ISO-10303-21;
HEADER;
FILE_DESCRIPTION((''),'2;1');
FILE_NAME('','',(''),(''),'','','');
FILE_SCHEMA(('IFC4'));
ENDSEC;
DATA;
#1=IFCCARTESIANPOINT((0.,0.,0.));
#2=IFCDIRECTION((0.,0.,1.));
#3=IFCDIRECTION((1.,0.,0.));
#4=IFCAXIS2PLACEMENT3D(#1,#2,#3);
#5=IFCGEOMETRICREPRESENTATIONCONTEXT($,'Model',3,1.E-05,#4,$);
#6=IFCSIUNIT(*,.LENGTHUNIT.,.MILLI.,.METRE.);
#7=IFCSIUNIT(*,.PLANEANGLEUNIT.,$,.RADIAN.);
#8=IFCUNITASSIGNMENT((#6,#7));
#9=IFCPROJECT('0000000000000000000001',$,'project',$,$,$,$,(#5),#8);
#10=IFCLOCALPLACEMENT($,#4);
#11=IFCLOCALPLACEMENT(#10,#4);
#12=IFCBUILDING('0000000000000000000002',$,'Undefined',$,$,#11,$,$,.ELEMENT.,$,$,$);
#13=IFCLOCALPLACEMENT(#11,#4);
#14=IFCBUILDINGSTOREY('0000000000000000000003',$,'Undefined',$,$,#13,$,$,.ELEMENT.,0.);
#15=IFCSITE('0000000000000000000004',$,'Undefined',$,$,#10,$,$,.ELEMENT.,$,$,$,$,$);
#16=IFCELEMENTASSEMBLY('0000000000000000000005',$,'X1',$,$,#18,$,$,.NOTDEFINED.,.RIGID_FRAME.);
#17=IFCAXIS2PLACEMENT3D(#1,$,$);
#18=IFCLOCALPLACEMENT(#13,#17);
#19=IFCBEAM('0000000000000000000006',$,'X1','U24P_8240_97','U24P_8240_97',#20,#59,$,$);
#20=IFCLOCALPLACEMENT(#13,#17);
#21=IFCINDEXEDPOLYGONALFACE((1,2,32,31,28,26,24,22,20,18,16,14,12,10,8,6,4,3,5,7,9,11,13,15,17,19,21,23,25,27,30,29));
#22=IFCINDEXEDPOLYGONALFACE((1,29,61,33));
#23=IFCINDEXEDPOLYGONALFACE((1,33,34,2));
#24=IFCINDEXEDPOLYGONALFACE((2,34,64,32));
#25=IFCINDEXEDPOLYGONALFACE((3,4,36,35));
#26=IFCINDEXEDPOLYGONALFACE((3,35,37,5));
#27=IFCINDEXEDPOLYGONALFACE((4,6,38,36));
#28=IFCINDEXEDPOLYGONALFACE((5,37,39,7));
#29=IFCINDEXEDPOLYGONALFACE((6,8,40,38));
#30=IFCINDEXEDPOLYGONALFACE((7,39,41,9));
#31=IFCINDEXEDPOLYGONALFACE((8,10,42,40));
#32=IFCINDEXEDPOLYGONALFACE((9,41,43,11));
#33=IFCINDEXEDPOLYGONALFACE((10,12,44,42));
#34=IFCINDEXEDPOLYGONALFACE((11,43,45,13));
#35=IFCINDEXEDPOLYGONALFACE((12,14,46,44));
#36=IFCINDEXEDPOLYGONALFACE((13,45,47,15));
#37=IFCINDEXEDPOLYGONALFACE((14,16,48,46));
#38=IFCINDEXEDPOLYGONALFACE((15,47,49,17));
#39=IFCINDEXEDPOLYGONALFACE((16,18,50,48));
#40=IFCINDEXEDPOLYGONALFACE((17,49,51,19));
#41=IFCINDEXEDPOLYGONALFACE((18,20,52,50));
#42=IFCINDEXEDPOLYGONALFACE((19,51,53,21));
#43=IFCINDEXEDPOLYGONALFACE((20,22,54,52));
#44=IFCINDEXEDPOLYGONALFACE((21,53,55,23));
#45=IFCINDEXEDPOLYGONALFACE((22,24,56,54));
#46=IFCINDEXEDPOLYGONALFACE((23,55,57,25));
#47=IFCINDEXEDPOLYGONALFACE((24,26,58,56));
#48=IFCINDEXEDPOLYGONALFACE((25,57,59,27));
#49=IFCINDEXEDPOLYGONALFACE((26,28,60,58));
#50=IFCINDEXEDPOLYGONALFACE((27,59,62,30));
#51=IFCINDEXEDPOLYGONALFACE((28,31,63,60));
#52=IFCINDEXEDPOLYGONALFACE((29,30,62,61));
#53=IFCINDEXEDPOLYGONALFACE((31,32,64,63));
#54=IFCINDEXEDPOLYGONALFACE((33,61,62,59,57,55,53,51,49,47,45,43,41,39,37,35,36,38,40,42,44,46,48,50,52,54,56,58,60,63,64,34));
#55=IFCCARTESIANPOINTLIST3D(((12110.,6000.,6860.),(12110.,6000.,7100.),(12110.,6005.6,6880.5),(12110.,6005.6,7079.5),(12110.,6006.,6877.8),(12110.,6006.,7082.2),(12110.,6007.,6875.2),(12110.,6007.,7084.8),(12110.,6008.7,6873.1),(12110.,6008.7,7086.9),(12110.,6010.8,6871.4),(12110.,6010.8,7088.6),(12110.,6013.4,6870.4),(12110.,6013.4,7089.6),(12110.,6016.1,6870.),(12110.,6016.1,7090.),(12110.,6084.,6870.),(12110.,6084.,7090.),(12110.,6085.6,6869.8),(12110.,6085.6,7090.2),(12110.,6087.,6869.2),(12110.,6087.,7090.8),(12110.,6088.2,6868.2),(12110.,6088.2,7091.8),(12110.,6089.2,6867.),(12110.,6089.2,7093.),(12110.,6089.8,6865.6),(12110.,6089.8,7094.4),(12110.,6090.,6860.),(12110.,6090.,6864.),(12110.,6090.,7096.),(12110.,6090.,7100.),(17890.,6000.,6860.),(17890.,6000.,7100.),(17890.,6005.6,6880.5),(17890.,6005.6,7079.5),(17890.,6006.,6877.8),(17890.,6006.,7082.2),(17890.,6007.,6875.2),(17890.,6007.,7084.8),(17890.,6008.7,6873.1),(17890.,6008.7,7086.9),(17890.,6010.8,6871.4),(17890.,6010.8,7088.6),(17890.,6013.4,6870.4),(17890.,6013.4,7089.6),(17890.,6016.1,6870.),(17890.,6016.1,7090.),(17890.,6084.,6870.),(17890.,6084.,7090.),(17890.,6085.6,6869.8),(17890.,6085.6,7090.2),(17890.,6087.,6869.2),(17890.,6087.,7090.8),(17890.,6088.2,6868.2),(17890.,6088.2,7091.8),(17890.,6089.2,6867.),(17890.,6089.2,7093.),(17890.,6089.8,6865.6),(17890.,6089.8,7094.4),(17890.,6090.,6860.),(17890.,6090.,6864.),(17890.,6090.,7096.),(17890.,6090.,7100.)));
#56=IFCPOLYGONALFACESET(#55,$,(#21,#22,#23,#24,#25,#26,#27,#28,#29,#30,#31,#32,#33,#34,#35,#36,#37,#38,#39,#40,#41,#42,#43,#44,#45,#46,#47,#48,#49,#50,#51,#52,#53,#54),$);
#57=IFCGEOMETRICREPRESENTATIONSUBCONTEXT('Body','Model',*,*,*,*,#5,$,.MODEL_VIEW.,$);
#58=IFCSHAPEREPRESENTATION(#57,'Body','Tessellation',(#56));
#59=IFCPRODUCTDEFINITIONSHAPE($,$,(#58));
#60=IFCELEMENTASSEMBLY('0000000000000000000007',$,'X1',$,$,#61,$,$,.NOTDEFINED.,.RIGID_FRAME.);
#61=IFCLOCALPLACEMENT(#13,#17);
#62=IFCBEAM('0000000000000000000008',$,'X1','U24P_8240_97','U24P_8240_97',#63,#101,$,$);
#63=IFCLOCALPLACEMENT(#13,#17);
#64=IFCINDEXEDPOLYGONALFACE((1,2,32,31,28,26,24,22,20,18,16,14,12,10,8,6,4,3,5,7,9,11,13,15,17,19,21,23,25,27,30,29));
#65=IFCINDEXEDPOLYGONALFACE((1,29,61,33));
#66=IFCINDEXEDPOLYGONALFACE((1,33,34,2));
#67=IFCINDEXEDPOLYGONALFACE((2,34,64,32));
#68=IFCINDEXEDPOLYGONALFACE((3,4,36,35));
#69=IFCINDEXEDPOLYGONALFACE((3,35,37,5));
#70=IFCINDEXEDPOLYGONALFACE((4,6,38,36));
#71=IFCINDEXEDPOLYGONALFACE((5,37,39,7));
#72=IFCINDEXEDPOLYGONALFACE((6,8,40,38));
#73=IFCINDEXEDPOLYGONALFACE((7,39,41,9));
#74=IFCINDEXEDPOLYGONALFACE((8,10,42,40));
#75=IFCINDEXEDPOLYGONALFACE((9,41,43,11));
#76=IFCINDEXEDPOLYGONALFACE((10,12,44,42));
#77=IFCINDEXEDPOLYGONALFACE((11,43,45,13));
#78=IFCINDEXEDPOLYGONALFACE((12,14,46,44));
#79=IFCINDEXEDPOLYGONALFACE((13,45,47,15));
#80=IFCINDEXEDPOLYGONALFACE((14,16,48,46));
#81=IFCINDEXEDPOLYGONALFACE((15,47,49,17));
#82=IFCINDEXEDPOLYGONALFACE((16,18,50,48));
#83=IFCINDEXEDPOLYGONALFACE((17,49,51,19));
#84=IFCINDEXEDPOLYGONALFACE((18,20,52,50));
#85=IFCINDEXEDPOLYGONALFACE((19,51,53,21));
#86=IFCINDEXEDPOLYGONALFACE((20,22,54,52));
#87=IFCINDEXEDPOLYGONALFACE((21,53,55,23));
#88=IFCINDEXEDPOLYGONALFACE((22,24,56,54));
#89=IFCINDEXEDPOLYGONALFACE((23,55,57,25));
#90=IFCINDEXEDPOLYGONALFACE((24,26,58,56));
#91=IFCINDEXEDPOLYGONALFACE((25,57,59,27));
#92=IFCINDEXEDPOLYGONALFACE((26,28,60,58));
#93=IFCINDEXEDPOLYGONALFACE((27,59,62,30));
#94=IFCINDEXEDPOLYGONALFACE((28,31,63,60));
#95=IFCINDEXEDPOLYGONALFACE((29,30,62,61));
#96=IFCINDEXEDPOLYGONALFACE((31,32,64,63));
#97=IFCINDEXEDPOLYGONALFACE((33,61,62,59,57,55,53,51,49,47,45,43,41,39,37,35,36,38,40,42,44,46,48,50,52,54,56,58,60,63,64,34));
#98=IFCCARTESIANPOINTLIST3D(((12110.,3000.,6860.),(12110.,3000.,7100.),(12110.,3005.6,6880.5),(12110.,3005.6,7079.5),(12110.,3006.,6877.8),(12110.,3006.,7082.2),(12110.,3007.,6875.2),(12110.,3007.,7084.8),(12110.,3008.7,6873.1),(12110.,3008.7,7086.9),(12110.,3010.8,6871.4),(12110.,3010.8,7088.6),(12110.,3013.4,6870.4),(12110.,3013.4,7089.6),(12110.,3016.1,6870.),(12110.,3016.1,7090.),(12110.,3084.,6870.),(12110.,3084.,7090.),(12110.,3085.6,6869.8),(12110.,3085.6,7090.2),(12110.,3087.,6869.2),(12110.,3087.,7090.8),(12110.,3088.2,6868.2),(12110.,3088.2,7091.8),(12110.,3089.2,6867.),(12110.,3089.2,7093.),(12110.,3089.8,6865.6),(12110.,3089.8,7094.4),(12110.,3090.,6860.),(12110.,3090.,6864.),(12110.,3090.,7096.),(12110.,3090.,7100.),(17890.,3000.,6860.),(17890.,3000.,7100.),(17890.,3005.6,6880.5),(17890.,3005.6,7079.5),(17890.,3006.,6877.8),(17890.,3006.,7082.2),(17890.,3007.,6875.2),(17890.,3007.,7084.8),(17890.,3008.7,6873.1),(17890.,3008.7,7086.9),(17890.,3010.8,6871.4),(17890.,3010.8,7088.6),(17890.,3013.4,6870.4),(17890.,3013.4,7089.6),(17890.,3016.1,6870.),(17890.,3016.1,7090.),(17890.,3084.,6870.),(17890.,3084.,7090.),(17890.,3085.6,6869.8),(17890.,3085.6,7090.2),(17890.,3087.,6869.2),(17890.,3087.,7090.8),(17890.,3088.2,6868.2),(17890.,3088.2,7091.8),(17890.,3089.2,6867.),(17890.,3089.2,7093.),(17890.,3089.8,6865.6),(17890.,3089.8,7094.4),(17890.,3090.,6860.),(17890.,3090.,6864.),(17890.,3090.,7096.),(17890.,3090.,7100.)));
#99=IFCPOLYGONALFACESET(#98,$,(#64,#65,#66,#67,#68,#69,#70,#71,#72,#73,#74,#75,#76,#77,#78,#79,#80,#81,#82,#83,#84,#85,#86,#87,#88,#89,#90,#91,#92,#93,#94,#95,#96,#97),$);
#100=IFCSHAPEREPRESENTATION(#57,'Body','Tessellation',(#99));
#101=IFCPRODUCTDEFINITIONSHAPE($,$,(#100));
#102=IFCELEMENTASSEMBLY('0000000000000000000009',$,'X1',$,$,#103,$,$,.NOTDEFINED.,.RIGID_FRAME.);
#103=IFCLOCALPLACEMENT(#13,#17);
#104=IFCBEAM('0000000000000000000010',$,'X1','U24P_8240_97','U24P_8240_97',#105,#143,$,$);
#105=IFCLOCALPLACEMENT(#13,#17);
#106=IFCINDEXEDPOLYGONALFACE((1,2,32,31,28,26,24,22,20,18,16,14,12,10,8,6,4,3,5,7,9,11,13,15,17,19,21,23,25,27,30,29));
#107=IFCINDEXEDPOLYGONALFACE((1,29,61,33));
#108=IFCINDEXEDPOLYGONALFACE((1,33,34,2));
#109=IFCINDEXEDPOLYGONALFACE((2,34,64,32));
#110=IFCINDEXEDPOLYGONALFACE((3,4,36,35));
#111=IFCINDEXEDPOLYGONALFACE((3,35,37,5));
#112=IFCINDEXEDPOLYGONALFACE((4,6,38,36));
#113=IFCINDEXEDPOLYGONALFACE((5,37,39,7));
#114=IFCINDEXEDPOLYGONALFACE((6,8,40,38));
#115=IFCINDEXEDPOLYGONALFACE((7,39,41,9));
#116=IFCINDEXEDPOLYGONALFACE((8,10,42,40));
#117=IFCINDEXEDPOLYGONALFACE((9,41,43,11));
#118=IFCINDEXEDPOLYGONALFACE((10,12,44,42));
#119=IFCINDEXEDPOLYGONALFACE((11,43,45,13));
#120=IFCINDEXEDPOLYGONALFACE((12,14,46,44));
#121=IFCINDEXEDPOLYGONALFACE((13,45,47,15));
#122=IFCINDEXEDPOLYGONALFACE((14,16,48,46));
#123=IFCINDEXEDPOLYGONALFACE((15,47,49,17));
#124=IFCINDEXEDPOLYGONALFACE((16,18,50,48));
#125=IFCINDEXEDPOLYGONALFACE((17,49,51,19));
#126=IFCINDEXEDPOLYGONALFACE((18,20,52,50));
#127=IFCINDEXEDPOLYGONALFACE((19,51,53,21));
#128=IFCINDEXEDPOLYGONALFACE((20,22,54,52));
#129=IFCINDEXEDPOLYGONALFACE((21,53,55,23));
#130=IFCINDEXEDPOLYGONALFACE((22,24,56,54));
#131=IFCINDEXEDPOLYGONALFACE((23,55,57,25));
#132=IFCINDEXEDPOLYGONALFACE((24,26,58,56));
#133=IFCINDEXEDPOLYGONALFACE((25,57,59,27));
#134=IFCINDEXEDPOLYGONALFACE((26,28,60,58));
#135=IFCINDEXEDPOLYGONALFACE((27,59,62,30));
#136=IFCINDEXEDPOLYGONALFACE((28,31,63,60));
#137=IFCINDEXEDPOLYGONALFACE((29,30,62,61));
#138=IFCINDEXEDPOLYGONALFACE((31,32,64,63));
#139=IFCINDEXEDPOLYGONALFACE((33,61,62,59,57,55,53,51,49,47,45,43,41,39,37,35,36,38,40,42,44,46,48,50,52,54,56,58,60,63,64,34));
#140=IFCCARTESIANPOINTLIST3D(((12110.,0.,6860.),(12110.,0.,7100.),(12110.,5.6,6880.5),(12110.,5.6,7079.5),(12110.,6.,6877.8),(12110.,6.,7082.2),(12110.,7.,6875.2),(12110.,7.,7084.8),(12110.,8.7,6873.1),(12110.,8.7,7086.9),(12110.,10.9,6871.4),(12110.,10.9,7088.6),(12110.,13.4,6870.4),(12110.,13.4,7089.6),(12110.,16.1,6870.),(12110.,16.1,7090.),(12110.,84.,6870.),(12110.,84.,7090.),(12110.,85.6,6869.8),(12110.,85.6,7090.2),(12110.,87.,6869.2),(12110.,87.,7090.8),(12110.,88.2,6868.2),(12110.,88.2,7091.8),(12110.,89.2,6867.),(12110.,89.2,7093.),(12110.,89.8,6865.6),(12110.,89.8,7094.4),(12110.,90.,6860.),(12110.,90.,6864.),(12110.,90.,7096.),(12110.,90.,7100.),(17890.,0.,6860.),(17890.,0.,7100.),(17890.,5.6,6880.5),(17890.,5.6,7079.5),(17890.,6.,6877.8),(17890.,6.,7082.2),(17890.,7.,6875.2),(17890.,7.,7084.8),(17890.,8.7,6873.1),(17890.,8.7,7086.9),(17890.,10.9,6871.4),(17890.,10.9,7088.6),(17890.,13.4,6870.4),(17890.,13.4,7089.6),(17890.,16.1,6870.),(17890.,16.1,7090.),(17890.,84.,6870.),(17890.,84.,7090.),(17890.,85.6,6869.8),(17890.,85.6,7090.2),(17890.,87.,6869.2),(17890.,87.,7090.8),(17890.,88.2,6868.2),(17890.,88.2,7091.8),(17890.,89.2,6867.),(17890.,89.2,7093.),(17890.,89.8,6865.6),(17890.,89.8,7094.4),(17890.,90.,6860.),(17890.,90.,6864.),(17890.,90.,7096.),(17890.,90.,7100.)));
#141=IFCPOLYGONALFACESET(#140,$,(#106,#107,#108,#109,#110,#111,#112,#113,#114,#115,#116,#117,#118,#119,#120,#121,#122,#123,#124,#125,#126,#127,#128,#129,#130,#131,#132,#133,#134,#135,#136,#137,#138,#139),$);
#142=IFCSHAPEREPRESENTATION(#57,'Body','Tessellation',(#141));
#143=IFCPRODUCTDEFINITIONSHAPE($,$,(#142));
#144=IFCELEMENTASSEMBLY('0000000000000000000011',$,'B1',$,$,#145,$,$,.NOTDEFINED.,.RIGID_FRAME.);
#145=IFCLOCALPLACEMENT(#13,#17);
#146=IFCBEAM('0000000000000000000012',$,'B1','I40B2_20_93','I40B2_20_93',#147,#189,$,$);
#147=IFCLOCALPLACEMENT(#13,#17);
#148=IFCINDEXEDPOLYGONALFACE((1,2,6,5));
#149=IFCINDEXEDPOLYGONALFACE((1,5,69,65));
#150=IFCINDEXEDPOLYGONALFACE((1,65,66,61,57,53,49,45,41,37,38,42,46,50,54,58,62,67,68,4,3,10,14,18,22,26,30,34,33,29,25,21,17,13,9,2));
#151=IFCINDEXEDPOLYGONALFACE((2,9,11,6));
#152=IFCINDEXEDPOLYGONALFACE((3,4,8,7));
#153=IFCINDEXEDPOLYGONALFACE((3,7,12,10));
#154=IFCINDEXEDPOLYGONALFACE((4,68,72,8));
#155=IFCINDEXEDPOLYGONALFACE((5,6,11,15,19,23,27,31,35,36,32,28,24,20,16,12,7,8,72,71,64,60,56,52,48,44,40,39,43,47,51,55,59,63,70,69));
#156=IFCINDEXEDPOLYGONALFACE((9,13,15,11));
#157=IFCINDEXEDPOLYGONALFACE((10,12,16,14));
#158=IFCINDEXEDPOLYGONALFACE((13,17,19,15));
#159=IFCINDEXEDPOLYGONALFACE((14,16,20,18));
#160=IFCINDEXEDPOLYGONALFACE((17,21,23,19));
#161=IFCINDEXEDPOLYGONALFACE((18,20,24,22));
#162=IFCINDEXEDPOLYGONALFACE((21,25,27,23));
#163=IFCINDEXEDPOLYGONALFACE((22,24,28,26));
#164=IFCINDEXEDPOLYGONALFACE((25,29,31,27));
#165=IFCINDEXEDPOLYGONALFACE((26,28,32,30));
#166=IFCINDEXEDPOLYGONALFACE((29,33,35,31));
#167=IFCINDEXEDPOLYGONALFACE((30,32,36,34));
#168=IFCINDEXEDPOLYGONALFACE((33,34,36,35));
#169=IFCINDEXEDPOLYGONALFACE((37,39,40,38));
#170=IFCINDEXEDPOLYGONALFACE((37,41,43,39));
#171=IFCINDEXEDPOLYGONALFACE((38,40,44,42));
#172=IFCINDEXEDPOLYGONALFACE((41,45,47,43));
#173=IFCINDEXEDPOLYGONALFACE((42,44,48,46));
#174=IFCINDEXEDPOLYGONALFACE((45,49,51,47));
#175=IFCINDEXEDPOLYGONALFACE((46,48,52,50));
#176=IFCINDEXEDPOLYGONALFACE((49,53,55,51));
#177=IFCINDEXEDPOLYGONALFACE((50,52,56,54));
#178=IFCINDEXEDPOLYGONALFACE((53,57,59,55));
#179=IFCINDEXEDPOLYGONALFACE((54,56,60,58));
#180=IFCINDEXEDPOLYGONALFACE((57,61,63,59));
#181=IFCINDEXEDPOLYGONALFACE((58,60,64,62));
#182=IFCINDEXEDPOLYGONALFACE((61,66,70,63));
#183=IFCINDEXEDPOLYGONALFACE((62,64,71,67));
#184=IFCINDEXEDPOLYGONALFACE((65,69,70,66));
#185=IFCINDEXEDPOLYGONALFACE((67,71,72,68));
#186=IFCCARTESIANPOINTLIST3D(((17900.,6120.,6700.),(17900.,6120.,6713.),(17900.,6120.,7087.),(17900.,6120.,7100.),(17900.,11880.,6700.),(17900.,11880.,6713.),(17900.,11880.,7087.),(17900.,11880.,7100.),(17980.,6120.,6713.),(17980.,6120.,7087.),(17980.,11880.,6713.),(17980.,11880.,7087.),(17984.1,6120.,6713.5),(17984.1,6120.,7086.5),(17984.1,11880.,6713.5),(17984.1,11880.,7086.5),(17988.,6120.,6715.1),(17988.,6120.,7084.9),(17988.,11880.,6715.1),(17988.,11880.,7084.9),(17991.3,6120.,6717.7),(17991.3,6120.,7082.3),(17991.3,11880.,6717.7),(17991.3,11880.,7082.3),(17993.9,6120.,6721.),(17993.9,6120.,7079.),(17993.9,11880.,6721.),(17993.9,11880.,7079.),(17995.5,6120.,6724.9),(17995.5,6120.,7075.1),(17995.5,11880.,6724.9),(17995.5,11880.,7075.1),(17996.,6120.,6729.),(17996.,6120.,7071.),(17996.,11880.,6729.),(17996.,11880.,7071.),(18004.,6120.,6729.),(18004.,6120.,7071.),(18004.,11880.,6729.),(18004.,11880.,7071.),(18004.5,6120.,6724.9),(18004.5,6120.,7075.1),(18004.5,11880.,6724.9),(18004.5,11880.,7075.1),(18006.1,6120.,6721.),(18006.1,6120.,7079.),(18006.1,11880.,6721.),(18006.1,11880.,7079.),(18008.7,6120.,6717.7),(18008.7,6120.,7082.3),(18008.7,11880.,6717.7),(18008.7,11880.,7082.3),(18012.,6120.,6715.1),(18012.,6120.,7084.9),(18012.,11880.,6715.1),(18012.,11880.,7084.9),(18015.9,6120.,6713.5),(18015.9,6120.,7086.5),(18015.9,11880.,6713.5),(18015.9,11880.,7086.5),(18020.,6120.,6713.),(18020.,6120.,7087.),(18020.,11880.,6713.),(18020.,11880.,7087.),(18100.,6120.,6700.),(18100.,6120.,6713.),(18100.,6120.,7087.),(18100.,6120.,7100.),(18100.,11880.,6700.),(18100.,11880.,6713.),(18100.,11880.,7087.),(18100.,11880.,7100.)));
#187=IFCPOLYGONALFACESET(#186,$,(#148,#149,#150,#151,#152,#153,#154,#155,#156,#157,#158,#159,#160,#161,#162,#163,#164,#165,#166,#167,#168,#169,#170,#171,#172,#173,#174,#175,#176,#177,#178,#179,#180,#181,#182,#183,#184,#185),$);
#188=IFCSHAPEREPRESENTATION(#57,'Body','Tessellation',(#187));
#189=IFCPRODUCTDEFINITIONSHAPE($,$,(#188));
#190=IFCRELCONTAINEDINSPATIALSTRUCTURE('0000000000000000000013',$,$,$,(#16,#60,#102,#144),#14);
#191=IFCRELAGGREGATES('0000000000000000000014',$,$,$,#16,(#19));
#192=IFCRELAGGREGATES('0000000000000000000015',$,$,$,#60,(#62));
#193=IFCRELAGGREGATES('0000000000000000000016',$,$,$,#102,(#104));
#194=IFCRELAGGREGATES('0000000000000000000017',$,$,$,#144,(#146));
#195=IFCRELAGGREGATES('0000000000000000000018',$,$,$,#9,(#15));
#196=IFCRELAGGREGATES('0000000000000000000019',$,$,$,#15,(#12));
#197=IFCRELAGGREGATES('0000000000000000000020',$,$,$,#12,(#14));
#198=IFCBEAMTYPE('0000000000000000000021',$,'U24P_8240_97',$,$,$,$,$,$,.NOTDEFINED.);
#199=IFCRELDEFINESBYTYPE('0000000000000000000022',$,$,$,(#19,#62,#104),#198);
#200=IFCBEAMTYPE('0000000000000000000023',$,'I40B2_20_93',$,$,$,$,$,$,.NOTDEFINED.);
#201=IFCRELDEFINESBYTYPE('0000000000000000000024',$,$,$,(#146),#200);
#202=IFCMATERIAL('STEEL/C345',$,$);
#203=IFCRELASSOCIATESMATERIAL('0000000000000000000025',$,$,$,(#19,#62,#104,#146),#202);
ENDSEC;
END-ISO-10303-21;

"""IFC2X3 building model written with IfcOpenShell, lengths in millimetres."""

from ifc_helpers import new_model, si_unit, frame, origin_with_axes, origin_2d_with_axis, place, context, subcontext, project, spatial, i_section, u_section, extrude, material, type_object, element, aggregate, save


model = new_model("IFC2X3")

# Units and contexts
model_context = context("Model", 3, precision=1e-05, world=origin_with_axes())
body_context = subcontext(model_context, "Body", "Model", "MODEL_VIEW")
ifc_project = project(units=[si_unit("LENGTHUNIT", "METRE", prefix="MILLI"), si_unit("PLANEANGLEUNIT", "RADIAN")], contexts=[model_context])

# Site, building, storey
site_placement = place(None, origin_with_axes())
site = spatial("IfcSite", under=ifc_project, at=site_placement, Name="Undefined", CompositionType="ELEMENT")
building_placement = place(site_placement, origin_with_axes())
building = spatial("IfcBuilding", under=site, at=building_placement, Name="Undefined", CompositionType="ELEMENT")
storey_placement = place(building_placement, origin_with_axes())
storey = spatial("IfcBuildingStorey", under=building, at=storey_placement, Name="Undefined", CompositionType="ELEMENT", Elevation=0.0)

# Element assemblies, beams
assembly_1_placement = place(storey_placement, origin_with_axes())
assembly_1 = element("IfcElementAssembly", 1, at=assembly_1_placement, inside=storey, Name="X1", AssemblyPlace="NOTDEFINED", PredefinedType="RIGID_FRAME")
ifc_material_1 = material(Name="STEEL/C345")
beam_type_1 = type_object("IfcBeamType", Name="U24P_8240_97", PredefinedType="NOTDEFINED")
beam_1_placement = place(assembly_1_placement, frame((12110.0, 6045.0, 6980.0), z_axis=(0.0, 0.0, -1.0), x_axis=(1.0, 0.0, 0.0)))
beam_1 = element("IfcBeam", 2, at=beam_1_placement, type_object=beam_type_1, material=ifc_material_1, Name="X1", Description="U24P_8240_97", ObjectType="U24P_8240_97", context=body_context, shape_type="SweptSolid", body=[
    extrude(u_section(Depth=240.0, FlangeWidth=90.0, WebThickness=5.6, FlangeThickness=10.0, FilletRadius=10.5, EdgeRadius=6.0, at=origin_2d_with_axis()), frame((5780.0, 0.0, 0.0), z_axis=(-1.0, 0.0, 0.0), x_axis=(0.0, -1.0, 0.0)), (0.0, 0.0, 1.0), 5780.0),
])
aggregate(assembly_1, [beam_1])
assembly_2_placement = place(storey_placement, origin_with_axes())
assembly_2 = element("IfcElementAssembly", 3, at=assembly_2_placement, inside=storey, Name="X1", AssemblyPlace="NOTDEFINED", PredefinedType="RIGID_FRAME")
beam_2_placement = place(assembly_2_placement, frame((12110.0, 3045.0, 6980.0), z_axis=(0.0, 0.0, -1.0), x_axis=(1.0, 0.0, 0.0)))
beam_2 = element("IfcBeam", 4, at=beam_2_placement, type_object=beam_type_1, material=ifc_material_1, Name="X1", Description="U24P_8240_97", ObjectType="U24P_8240_97", context=body_context, shape_type="SweptSolid", body=[
    extrude(u_section(Depth=240.0, FlangeWidth=90.0, WebThickness=5.6, FlangeThickness=10.0, FilletRadius=10.5, EdgeRadius=6.0, at=origin_2d_with_axis()), frame((5780.0, 0.0, 0.0), z_axis=(-1.0, 0.0, 0.0), x_axis=(0.0, -1.0, 0.0)), (0.0, 0.0, 1.0), 5780.0),
])
aggregate(assembly_2, [beam_2])
assembly_3_placement = place(storey_placement, origin_with_axes())
assembly_3 = element("IfcElementAssembly", 5, at=assembly_3_placement, inside=storey, Name="X1", AssemblyPlace="NOTDEFINED", PredefinedType="RIGID_FRAME")
beam_3_placement = place(assembly_3_placement, frame((12110.0, 45.0, 6980.0), z_axis=(0.0, 0.0, -1.0), x_axis=(1.0, 0.0, 0.0)))
beam_3 = element("IfcBeam", 6, at=beam_3_placement, type_object=beam_type_1, material=ifc_material_1, Name="X1", Description="U24P_8240_97", ObjectType="U24P_8240_97", context=body_context, shape_type="SweptSolid", body=[
    extrude(u_section(Depth=240.0, FlangeWidth=90.0, WebThickness=5.6, FlangeThickness=10.0, FilletRadius=10.5, EdgeRadius=6.0, at=origin_2d_with_axis()), frame((5780.0, 0.0, 0.0), z_axis=(-1.0, 0.0, 0.0), x_axis=(0.0, -1.0, 0.0)), (0.0, 0.0, 1.0), 5780.0),
])
aggregate(assembly_3, [beam_3])
assembly_4_placement = place(storey_placement, origin_with_axes())
assembly_4 = element("IfcElementAssembly", 7, at=assembly_4_placement, inside=storey, Name="B1", AssemblyPlace="NOTDEFINED", PredefinedType="RIGID_FRAME")
beam_type_2 = type_object("IfcBeamType", Name="I40B2_20_93", PredefinedType="NOTDEFINED")
beam_4_placement = place(assembly_4_placement, frame((18000.0, 6120.0, 6900.0), z_axis=(0.0, 0.0, 1.0), x_axis=(0.0, 1.0, 0.0)))
beam_4 = element("IfcBeam", 8, at=beam_4_placement, type_object=beam_type_2, material=ifc_material_1, Name="B1", Description="I40B2_20_93", ObjectType="I40B2_20_93", context=body_context, shape_type="SweptSolid", body=[
    extrude(i_section(OverallWidth=200.0, OverallDepth=400.0, WebThickness=8.0, FlangeThickness=13.0, FilletRadius=16.0, at=origin_2d_with_axis()), frame((5760.0, 0.0, 0.0), z_axis=(-1.0, 0.0, 0.0), x_axis=(0.0, -1.0, 0.0)), (0.0, 0.0, 1.0), 5760.0),
])
aggregate(assembly_4, [beam_4])

save(model, "model.ifc")
